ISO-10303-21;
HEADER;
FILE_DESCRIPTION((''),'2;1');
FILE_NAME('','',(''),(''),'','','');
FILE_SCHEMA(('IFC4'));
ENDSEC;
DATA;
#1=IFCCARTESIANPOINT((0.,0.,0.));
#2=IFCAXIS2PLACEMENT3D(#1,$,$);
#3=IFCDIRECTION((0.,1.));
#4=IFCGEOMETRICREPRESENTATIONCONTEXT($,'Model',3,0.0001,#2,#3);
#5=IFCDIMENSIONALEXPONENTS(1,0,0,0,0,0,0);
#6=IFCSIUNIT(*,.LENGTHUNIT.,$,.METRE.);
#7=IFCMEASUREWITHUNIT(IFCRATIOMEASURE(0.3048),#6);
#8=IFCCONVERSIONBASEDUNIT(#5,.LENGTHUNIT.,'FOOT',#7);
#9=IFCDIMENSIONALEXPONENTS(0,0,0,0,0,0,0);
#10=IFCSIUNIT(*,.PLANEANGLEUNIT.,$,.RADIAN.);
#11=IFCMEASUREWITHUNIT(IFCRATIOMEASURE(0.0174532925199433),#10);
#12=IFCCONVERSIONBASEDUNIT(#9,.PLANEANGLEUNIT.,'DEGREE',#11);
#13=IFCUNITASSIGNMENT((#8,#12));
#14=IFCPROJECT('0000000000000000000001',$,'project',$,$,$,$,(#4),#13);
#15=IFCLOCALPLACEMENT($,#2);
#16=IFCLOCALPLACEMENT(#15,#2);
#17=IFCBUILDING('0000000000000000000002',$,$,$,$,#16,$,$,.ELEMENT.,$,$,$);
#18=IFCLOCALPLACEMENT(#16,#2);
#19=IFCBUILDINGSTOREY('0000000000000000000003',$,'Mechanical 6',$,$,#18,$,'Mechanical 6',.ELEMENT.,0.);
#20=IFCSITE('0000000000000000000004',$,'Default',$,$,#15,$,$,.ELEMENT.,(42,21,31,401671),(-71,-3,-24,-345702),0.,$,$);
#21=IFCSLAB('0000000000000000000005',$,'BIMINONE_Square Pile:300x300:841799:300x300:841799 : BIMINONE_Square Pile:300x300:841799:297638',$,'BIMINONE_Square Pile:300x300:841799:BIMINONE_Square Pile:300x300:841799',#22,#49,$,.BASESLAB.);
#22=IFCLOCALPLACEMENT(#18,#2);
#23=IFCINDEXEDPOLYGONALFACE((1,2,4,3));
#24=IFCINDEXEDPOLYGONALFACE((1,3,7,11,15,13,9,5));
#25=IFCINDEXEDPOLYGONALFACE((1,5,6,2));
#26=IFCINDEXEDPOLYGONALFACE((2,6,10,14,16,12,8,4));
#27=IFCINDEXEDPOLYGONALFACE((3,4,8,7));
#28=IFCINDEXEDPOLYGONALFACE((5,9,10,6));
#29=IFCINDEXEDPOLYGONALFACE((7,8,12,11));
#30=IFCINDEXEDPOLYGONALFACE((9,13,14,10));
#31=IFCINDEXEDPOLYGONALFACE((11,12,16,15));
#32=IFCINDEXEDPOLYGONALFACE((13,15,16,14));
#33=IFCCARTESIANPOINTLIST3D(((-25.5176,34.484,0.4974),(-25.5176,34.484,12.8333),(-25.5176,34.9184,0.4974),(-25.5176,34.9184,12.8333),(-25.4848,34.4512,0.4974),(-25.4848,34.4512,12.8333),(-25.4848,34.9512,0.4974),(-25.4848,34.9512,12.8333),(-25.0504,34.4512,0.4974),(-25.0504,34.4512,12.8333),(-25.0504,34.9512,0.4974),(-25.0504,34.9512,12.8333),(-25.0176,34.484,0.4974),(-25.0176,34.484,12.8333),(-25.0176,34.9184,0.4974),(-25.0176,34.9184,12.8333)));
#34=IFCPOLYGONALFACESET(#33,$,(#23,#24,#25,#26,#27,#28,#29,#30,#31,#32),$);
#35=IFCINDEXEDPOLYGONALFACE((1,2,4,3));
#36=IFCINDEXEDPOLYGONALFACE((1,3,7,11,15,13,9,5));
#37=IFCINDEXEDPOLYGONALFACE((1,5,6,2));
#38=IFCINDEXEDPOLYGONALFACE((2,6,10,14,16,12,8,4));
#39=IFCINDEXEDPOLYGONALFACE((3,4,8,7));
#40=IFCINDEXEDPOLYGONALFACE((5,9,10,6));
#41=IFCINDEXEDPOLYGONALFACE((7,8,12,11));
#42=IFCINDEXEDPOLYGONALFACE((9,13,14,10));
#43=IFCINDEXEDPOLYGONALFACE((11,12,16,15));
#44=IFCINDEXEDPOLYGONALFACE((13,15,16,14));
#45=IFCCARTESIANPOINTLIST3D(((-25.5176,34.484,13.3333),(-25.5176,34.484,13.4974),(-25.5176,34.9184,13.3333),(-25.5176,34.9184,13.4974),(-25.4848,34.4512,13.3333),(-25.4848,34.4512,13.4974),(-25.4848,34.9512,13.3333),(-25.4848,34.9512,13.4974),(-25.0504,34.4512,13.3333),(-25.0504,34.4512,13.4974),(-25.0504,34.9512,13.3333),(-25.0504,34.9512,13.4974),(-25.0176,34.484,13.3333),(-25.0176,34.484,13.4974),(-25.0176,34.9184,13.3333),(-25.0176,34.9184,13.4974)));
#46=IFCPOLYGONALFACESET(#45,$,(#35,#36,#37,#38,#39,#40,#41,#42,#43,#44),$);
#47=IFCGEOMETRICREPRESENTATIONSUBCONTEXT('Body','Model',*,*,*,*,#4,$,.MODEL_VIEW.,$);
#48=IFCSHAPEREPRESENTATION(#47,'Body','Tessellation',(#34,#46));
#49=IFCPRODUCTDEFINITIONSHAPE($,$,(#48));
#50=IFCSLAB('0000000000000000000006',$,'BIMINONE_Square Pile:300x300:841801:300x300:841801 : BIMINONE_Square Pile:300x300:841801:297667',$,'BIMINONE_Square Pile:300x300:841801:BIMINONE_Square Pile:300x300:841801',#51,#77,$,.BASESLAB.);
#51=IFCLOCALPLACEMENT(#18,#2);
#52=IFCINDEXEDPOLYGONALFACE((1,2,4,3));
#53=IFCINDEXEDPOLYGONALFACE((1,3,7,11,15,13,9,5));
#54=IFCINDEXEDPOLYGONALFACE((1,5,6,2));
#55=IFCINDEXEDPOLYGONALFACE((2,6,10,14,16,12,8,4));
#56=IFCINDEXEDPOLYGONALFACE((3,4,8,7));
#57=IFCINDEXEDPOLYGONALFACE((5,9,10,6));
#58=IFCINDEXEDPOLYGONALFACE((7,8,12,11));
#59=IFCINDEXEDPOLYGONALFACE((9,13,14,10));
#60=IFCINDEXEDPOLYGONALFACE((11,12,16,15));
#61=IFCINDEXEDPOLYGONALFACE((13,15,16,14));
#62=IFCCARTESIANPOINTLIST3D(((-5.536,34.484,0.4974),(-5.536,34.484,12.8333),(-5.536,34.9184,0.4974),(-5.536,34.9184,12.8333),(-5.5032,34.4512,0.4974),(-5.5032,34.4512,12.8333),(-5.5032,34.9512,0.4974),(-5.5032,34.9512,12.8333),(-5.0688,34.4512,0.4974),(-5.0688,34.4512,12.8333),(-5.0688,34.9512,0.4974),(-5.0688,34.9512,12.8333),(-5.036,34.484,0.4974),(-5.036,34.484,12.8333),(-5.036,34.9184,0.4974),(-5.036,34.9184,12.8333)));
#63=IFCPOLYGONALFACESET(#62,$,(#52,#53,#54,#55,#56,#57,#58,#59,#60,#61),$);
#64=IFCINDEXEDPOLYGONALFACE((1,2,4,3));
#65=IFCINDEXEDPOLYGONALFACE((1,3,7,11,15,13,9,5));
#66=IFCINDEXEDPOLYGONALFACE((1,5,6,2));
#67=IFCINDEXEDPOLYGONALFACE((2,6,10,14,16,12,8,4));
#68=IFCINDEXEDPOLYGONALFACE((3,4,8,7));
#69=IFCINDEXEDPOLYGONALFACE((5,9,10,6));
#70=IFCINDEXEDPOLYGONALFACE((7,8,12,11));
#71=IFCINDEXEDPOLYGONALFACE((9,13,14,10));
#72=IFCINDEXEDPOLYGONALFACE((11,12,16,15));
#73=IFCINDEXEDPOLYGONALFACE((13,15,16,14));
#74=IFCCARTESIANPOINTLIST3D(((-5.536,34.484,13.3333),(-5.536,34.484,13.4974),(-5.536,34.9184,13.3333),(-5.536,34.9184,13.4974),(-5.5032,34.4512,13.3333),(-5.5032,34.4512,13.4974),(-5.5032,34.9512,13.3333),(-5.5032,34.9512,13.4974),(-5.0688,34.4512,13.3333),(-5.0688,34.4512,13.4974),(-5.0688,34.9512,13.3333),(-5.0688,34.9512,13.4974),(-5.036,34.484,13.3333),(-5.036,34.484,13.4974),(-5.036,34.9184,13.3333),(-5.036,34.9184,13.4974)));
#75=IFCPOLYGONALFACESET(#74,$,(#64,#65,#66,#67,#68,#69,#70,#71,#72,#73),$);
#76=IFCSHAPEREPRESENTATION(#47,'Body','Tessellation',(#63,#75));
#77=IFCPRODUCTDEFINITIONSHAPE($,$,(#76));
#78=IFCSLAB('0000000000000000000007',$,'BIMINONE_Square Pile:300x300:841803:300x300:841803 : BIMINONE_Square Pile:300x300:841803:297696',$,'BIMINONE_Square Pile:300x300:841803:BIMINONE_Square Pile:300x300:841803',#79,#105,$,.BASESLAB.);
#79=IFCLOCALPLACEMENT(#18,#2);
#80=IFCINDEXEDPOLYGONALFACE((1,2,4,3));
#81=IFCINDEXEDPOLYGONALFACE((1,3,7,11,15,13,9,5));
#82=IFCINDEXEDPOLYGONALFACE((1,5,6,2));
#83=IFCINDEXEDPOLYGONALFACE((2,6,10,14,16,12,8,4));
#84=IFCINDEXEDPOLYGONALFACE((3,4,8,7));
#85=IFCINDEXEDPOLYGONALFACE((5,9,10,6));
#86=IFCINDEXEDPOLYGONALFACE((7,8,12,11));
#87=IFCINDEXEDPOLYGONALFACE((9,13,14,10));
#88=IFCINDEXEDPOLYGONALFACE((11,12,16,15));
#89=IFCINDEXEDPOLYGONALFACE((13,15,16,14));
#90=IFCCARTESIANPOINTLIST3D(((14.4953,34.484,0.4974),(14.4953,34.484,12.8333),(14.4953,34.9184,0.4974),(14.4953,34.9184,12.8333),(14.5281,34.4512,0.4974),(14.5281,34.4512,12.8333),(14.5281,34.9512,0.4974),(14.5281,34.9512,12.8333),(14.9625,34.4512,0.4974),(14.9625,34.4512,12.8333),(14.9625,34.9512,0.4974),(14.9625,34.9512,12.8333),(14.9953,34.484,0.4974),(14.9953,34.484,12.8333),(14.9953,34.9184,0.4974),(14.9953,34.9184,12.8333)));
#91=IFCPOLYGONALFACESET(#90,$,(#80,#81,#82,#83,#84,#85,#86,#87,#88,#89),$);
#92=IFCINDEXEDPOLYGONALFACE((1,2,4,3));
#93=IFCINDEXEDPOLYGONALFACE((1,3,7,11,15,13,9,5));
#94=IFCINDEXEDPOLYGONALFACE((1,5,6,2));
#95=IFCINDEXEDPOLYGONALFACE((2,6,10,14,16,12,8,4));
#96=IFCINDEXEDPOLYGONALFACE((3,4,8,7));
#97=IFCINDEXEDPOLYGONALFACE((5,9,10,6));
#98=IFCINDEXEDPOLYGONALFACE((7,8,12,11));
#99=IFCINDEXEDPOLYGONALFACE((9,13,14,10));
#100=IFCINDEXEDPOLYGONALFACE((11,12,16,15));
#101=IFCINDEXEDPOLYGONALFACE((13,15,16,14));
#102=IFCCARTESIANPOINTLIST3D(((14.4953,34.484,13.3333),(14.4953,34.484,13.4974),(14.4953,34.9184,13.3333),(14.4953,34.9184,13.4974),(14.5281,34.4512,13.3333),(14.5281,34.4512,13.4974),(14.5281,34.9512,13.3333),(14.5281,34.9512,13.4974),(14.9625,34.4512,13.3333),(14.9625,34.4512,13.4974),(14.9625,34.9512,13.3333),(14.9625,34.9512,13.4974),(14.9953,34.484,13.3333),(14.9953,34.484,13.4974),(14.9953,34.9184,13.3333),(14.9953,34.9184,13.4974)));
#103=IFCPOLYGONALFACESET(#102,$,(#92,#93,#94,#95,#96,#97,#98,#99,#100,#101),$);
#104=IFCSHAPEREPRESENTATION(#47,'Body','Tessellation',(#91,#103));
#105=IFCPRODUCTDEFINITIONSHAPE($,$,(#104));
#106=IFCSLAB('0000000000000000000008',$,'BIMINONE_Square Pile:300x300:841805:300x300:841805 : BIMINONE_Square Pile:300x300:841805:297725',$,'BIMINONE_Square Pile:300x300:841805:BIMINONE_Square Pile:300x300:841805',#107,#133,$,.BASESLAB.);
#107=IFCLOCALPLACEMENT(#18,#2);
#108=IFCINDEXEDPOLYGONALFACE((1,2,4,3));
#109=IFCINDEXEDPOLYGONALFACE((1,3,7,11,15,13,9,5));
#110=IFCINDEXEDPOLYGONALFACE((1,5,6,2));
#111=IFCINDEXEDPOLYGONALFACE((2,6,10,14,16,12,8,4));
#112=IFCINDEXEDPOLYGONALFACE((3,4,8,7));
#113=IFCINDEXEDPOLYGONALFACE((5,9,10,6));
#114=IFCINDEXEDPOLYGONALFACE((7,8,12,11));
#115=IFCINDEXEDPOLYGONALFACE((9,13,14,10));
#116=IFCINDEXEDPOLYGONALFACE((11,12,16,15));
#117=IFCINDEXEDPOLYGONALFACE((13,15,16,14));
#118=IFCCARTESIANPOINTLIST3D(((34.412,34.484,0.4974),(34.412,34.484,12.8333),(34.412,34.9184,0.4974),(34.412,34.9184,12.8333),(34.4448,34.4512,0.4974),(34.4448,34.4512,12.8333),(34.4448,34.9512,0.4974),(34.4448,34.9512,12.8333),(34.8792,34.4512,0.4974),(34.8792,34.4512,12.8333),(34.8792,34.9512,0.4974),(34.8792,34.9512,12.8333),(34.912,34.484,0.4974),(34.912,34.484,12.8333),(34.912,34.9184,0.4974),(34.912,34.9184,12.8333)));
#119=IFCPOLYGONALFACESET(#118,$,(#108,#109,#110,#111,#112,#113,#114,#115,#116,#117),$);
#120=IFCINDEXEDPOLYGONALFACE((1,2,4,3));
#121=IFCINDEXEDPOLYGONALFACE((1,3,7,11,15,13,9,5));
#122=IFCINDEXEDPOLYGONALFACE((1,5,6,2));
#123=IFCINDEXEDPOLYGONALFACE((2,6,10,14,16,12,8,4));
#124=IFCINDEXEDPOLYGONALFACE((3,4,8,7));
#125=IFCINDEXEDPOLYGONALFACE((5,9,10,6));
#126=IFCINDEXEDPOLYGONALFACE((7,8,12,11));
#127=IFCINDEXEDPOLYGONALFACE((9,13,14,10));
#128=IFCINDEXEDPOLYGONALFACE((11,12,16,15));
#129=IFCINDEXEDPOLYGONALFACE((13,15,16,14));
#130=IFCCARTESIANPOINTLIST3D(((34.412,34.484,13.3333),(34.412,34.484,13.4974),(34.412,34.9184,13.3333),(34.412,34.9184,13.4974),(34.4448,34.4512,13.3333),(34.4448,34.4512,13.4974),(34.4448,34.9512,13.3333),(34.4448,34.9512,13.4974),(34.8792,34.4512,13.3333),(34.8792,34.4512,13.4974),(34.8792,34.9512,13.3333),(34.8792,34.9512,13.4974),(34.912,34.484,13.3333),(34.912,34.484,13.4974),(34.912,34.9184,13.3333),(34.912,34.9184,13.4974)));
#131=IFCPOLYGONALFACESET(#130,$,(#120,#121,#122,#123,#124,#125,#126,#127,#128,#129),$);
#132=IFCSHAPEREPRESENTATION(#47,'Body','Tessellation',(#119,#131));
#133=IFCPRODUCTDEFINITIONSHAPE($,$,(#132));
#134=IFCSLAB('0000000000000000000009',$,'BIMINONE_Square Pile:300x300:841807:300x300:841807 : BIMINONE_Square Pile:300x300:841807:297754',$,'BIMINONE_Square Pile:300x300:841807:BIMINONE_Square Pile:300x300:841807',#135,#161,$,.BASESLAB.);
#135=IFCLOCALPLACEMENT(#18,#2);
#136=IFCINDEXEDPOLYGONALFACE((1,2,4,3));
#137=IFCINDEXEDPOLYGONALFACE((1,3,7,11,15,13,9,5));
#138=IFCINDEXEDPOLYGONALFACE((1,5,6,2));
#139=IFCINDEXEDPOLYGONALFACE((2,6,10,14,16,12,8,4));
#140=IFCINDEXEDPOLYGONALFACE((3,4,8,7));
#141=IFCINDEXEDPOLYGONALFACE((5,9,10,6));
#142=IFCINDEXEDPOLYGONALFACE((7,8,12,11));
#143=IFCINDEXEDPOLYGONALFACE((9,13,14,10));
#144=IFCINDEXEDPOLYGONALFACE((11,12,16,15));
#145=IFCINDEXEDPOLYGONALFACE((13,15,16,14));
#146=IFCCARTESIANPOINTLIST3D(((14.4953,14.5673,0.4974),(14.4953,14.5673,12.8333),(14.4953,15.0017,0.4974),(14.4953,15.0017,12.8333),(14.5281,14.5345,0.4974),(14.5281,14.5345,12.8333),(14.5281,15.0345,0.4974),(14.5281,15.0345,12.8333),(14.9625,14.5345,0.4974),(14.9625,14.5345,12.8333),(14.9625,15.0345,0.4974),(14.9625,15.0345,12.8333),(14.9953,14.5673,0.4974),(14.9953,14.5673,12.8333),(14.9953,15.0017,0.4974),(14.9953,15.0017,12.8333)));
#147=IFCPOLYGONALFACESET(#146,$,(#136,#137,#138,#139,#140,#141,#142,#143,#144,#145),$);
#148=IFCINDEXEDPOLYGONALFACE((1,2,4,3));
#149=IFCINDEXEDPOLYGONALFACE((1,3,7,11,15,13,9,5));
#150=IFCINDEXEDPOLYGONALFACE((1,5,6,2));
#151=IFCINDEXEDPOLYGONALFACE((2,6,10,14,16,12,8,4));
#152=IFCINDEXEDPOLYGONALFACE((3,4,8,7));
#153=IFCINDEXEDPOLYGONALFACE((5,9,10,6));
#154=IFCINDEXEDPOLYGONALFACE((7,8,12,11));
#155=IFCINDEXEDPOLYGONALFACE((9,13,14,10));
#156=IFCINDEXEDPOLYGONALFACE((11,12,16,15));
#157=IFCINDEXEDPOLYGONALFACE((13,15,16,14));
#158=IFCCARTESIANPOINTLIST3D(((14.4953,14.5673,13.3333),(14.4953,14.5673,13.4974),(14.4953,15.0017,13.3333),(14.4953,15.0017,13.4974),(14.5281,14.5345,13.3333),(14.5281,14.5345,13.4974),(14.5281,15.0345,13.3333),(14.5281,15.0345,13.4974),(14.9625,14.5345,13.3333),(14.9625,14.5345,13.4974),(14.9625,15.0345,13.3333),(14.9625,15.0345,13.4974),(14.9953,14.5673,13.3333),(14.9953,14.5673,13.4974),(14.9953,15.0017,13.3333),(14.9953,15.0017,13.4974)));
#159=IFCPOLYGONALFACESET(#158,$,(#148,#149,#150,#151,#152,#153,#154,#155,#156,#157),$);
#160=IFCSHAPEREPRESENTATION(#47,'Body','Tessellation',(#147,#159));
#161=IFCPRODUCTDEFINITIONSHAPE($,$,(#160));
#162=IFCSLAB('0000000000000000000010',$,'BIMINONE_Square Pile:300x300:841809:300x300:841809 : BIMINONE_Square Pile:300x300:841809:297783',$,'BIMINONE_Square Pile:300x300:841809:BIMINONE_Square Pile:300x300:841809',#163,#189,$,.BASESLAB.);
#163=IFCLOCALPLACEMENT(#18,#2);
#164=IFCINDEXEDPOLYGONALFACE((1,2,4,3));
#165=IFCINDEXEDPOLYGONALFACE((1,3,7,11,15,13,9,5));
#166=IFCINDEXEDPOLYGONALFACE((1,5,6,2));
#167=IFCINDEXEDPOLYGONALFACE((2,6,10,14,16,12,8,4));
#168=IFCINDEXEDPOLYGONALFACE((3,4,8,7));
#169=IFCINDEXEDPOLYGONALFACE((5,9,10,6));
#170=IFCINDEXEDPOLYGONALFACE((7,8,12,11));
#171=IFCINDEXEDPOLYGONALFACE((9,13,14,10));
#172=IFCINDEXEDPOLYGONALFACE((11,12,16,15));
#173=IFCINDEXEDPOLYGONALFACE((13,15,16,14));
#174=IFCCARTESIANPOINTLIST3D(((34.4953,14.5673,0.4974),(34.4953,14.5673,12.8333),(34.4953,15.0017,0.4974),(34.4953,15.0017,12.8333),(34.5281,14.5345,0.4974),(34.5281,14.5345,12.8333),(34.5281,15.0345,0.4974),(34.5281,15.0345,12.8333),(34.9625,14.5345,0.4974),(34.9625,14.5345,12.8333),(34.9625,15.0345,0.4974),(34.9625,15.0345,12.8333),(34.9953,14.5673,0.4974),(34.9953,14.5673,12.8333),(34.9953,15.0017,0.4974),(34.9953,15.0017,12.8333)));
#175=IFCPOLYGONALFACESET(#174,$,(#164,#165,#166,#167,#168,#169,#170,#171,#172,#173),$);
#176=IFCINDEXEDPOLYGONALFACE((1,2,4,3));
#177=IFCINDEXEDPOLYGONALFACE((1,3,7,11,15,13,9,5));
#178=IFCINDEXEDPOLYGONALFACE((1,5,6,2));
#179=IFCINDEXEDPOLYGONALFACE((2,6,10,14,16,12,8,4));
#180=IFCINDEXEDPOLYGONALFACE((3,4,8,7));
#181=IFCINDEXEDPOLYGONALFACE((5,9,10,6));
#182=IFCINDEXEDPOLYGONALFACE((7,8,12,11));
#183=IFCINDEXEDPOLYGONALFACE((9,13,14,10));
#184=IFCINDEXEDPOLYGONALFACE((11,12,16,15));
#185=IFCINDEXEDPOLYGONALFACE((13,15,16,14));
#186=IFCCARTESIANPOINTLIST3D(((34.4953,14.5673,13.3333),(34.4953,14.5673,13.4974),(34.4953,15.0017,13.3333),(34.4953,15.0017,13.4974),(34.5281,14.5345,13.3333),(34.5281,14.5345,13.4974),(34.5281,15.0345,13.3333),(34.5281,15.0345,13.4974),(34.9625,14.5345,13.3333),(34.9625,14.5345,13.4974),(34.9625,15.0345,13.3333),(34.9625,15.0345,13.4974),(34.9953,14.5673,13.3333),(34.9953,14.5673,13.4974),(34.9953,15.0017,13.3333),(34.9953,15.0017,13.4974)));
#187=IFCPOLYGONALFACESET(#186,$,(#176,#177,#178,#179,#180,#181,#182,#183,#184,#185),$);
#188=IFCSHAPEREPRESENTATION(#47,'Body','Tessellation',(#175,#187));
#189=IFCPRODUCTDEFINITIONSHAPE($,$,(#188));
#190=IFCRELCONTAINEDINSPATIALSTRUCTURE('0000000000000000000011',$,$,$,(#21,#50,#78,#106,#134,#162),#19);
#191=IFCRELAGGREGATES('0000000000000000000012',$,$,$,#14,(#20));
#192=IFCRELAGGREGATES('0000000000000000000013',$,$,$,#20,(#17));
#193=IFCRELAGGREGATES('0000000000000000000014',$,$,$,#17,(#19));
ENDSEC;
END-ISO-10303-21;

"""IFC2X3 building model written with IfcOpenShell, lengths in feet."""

from ifc_helpers import new_model, entity, si_unit, converted_unit, direction, frame, origin, place, context, subcontext, project, spatial, polyline, outline, extrude, element, save


model = new_model("IFC2X3")

# Units and contexts
model_context = context("Model", 3, precision=0.0001, world=origin(), true_north=direction((0.0, 1.0)))
body_context = subcontext(model_context, "Body", "Model", "MODEL_VIEW")
ifc_project = project(units=[converted_unit("LENGTHUNIT", "FOOT", entity("IfcRatioMeasure", 0.3048), si_unit("LENGTHUNIT", "METRE"), dimensions=[1, 0, 0, 0, 0, 0, 0]), converted_unit("PLANEANGLEUNIT", "DEGREE", entity("IfcRatioMeasure", 0.0174532925199433), si_unit("PLANEANGLEUNIT", "RADIAN"), dimensions=[0, 0, 0, 0, 0, 0, 0])], contexts=[model_context])

# Site, building, storey
site_placement = place(None, origin())
site = spatial("IfcSite", under=ifc_project, at=site_placement, Name="Default", CompositionType="ELEMENT", RefLatitude=(42, 21, 31, 401671), RefLongitude=(-71, -3, -24, -345702), RefElevation=0.0)
building_placement = place(site_placement, origin())
building = spatial("IfcBuilding", under=site, at=building_placement, CompositionType="ELEMENT")
storey_placement = place(building_placement, origin())
storey = spatial("IfcBuildingStorey", under=building, at=storey_placement, Name="Mechanical 6", LongName="Mechanical 6", CompositionType="ELEMENT", Elevation=0.0)

# Slabs
slab_1_placement = place(building_placement, origin())
element("IfcSlab", 1, at=slab_1_placement, inside=storey, Name="BIMINONE_Square Pile:300x300:841799:300x300:841799 : BIMINONE_Square Pile:300x300:841799:297638", ObjectType="BIMINONE_Square Pile:300x300:841799:BIMINONE_Square Pile:300x300:841799", PredefinedType="BASESLAB", context=body_context, shape_type="SweptSolid", body=[
    extrude(outline(polyline([(-0.0232, -0.3304), (0.0232, -0.3304), (0.3304, -0.0232), (0.3304, 0.0232), (0.0232, 0.3304), (-0.0232, 0.3304), (-0.3304, 0.0232), (-0.3304, -0.0232), (-0.0232, -0.3304)])), frame((-25.2676, 34.7012, 0.4974), z_axis=(0.0, 0.0, 1.0), x_axis=(0.707107, -0.707107, 0.0)), (0.0, 0.0, 1.0), 12.336),
    extrude(outline(polyline([(-0.2172, -0.25), (0.2172, -0.25), (0.25, -0.2172), (0.25, 0.2172), (0.2172, 0.25), (-0.2172, 0.25), (-0.25, 0.2172), (-0.25, -0.2172), (-0.2172, -0.25)])), frame((-25.2676, 34.7012, 13.3333)), (0.0, 0.0, 1.0), 0.164),
])
slab_2_placement = place(building_placement, origin())
element("IfcSlab", 2, at=slab_2_placement, inside=storey, Name="BIMINONE_Square Pile:300x300:841801:300x300:841801 : BIMINONE_Square Pile:300x300:841801:297667", ObjectType="BIMINONE_Square Pile:300x300:841801:BIMINONE_Square Pile:300x300:841801", PredefinedType="BASESLAB", context=body_context, shape_type="SweptSolid", body=[
    extrude(outline(polyline([(-0.0232, -0.3304), (0.0232, -0.3304), (0.3304, -0.0232), (0.3304, 0.0232), (0.0232, 0.3304), (-0.0232, 0.3304), (-0.3304, 0.0232), (-0.3304, -0.0232), (-0.0232, -0.3304)])), frame((-5.286, 34.7012, 0.4974), z_axis=(0.0, 0.0, 1.0), x_axis=(0.707107, -0.707107, 0.0)), (0.0, 0.0, 1.0), 12.336),
    extrude(outline(polyline([(-0.2172, -0.25), (0.2172, -0.25), (0.25, -0.2172), (0.25, 0.2172), (0.2172, 0.25), (-0.2172, 0.25), (-0.25, 0.2172), (-0.25, -0.2172), (-0.2172, -0.25)])), frame((-5.286, 34.7012, 13.3333)), (0.0, 0.0, 1.0), 0.164),
])
slab_3_placement = place(building_placement, origin())
element("IfcSlab", 3, at=slab_3_placement, inside=storey, Name="BIMINONE_Square Pile:300x300:841803:300x300:841803 : BIMINONE_Square Pile:300x300:841803:297696", ObjectType="BIMINONE_Square Pile:300x300:841803:BIMINONE_Square Pile:300x300:841803", PredefinedType="BASESLAB", context=body_context, shape_type="SweptSolid", body=[
    extrude(outline(polyline([(-0.0232, -0.3304), (0.0232, -0.3304), (0.3304, -0.0232), (0.3304, 0.0232), (0.0232, 0.3304), (-0.0232, 0.3304), (-0.3304, 0.0232), (-0.3304, -0.0232), (-0.0232, -0.3304)])), frame((14.7453, 34.7012, 0.4974), z_axis=(0.0, 0.0, 1.0), x_axis=(0.707107, -0.707107, 0.0)), (0.0, 0.0, 1.0), 12.336),
    extrude(outline(polyline([(-0.2172, -0.25), (0.2172, -0.25), (0.25, -0.2172), (0.25, 0.2172), (0.2172, 0.25), (-0.2172, 0.25), (-0.25, 0.2172), (-0.25, -0.2172), (-0.2172, -0.25)])), frame((14.7453, 34.7012, 13.3333)), (0.0, 0.0, 1.0), 0.164),
])
slab_4_placement = place(building_placement, origin())
element("IfcSlab", 4, at=slab_4_placement, inside=storey, Name="BIMINONE_Square Pile:300x300:841805:300x300:841805 : BIMINONE_Square Pile:300x300:841805:297725", ObjectType="BIMINONE_Square Pile:300x300:841805:BIMINONE_Square Pile:300x300:841805", PredefinedType="BASESLAB", context=body_context, shape_type="SweptSolid", body=[
    extrude(outline(polyline([(-0.0232, -0.3304), (0.0232, -0.3304), (0.3304, -0.0232), (0.3304, 0.0232), (0.0232, 0.3304), (-0.0232, 0.3304), (-0.3304, 0.0232), (-0.3304, -0.0232), (-0.0232, -0.3304)])), frame((34.662, 34.7012, 0.4974), z_axis=(0.0, 0.0, 1.0), x_axis=(0.707107, -0.707107, 0.0)), (0.0, 0.0, 1.0), 12.336),
    extrude(outline(polyline([(-0.2172, -0.25), (0.2172, -0.25), (0.25, -0.2172), (0.25, 0.2172), (0.2172, 0.25), (-0.2172, 0.25), (-0.25, 0.2172), (-0.25, -0.2172), (-0.2172, -0.25)])), frame((34.662, 34.7012, 13.3333)), (0.0, 0.0, 1.0), 0.164),
])
slab_5_placement = place(building_placement, origin())
element("IfcSlab", 5, at=slab_5_placement, inside=storey, Name="BIMINONE_Square Pile:300x300:841807:300x300:841807 : BIMINONE_Square Pile:300x300:841807:297754", ObjectType="BIMINONE_Square Pile:300x300:841807:BIMINONE_Square Pile:300x300:841807", PredefinedType="BASESLAB", context=body_context, shape_type="SweptSolid", body=[
    extrude(outline(polyline([(-0.0232, -0.3304), (0.0232, -0.3304), (0.3304, -0.0232), (0.3304, 0.0232), (0.0232, 0.3304), (-0.0232, 0.3304), (-0.3304, 0.0232), (-0.3304, -0.0232), (-0.0232, -0.3304)])), frame((14.7453, 14.7845, 0.4974), z_axis=(0.0, 0.0, 1.0), x_axis=(0.707107, -0.707107, 0.0)), (0.0, 0.0, 1.0), 12.336),
    extrude(outline(polyline([(-0.2172, -0.25), (0.2172, -0.25), (0.25, -0.2172), (0.25, 0.2172), (0.2172, 0.25), (-0.2172, 0.25), (-0.25, 0.2172), (-0.25, -0.2172), (-0.2172, -0.25)])), frame((14.7453, 14.7845, 13.3333)), (0.0, 0.0, 1.0), 0.164),
])
slab_6_placement = place(building_placement, origin())
element("IfcSlab", 6, at=slab_6_placement, inside=storey, Name="BIMINONE_Square Pile:300x300:841809:300x300:841809 : BIMINONE_Square Pile:300x300:841809:297783", ObjectType="BIMINONE_Square Pile:300x300:841809:BIMINONE_Square Pile:300x300:841809", PredefinedType="BASESLAB", context=body_context, shape_type="SweptSolid", body=[
    extrude(outline(polyline([(-0.0232, -0.3304), (0.0232, -0.3304), (0.3304, -0.0232), (0.3304, 0.0232), (0.0232, 0.3304), (-0.0232, 0.3304), (-0.3304, 0.0232), (-0.3304, -0.0232), (-0.0232, -0.3304)])), frame((34.7453, 14.7845, 0.4974), z_axis=(0.0, 0.0, 1.0), x_axis=(0.707107, -0.707107, 0.0)), (0.0, 0.0, 1.0), 12.336),
    extrude(outline(polyline([(-0.2172, -0.25), (0.2172, -0.25), (0.25, -0.2172), (0.25, 0.2172), (0.2172, 0.25), (-0.2172, 0.25), (-0.25, 0.2172), (-0.25, -0.2172), (-0.2172, -0.25)])), frame((34.7453, 14.7845, 13.3333)), (0.0, 0.0, 1.0), 0.164),
])

save(model, "model.ifc")
